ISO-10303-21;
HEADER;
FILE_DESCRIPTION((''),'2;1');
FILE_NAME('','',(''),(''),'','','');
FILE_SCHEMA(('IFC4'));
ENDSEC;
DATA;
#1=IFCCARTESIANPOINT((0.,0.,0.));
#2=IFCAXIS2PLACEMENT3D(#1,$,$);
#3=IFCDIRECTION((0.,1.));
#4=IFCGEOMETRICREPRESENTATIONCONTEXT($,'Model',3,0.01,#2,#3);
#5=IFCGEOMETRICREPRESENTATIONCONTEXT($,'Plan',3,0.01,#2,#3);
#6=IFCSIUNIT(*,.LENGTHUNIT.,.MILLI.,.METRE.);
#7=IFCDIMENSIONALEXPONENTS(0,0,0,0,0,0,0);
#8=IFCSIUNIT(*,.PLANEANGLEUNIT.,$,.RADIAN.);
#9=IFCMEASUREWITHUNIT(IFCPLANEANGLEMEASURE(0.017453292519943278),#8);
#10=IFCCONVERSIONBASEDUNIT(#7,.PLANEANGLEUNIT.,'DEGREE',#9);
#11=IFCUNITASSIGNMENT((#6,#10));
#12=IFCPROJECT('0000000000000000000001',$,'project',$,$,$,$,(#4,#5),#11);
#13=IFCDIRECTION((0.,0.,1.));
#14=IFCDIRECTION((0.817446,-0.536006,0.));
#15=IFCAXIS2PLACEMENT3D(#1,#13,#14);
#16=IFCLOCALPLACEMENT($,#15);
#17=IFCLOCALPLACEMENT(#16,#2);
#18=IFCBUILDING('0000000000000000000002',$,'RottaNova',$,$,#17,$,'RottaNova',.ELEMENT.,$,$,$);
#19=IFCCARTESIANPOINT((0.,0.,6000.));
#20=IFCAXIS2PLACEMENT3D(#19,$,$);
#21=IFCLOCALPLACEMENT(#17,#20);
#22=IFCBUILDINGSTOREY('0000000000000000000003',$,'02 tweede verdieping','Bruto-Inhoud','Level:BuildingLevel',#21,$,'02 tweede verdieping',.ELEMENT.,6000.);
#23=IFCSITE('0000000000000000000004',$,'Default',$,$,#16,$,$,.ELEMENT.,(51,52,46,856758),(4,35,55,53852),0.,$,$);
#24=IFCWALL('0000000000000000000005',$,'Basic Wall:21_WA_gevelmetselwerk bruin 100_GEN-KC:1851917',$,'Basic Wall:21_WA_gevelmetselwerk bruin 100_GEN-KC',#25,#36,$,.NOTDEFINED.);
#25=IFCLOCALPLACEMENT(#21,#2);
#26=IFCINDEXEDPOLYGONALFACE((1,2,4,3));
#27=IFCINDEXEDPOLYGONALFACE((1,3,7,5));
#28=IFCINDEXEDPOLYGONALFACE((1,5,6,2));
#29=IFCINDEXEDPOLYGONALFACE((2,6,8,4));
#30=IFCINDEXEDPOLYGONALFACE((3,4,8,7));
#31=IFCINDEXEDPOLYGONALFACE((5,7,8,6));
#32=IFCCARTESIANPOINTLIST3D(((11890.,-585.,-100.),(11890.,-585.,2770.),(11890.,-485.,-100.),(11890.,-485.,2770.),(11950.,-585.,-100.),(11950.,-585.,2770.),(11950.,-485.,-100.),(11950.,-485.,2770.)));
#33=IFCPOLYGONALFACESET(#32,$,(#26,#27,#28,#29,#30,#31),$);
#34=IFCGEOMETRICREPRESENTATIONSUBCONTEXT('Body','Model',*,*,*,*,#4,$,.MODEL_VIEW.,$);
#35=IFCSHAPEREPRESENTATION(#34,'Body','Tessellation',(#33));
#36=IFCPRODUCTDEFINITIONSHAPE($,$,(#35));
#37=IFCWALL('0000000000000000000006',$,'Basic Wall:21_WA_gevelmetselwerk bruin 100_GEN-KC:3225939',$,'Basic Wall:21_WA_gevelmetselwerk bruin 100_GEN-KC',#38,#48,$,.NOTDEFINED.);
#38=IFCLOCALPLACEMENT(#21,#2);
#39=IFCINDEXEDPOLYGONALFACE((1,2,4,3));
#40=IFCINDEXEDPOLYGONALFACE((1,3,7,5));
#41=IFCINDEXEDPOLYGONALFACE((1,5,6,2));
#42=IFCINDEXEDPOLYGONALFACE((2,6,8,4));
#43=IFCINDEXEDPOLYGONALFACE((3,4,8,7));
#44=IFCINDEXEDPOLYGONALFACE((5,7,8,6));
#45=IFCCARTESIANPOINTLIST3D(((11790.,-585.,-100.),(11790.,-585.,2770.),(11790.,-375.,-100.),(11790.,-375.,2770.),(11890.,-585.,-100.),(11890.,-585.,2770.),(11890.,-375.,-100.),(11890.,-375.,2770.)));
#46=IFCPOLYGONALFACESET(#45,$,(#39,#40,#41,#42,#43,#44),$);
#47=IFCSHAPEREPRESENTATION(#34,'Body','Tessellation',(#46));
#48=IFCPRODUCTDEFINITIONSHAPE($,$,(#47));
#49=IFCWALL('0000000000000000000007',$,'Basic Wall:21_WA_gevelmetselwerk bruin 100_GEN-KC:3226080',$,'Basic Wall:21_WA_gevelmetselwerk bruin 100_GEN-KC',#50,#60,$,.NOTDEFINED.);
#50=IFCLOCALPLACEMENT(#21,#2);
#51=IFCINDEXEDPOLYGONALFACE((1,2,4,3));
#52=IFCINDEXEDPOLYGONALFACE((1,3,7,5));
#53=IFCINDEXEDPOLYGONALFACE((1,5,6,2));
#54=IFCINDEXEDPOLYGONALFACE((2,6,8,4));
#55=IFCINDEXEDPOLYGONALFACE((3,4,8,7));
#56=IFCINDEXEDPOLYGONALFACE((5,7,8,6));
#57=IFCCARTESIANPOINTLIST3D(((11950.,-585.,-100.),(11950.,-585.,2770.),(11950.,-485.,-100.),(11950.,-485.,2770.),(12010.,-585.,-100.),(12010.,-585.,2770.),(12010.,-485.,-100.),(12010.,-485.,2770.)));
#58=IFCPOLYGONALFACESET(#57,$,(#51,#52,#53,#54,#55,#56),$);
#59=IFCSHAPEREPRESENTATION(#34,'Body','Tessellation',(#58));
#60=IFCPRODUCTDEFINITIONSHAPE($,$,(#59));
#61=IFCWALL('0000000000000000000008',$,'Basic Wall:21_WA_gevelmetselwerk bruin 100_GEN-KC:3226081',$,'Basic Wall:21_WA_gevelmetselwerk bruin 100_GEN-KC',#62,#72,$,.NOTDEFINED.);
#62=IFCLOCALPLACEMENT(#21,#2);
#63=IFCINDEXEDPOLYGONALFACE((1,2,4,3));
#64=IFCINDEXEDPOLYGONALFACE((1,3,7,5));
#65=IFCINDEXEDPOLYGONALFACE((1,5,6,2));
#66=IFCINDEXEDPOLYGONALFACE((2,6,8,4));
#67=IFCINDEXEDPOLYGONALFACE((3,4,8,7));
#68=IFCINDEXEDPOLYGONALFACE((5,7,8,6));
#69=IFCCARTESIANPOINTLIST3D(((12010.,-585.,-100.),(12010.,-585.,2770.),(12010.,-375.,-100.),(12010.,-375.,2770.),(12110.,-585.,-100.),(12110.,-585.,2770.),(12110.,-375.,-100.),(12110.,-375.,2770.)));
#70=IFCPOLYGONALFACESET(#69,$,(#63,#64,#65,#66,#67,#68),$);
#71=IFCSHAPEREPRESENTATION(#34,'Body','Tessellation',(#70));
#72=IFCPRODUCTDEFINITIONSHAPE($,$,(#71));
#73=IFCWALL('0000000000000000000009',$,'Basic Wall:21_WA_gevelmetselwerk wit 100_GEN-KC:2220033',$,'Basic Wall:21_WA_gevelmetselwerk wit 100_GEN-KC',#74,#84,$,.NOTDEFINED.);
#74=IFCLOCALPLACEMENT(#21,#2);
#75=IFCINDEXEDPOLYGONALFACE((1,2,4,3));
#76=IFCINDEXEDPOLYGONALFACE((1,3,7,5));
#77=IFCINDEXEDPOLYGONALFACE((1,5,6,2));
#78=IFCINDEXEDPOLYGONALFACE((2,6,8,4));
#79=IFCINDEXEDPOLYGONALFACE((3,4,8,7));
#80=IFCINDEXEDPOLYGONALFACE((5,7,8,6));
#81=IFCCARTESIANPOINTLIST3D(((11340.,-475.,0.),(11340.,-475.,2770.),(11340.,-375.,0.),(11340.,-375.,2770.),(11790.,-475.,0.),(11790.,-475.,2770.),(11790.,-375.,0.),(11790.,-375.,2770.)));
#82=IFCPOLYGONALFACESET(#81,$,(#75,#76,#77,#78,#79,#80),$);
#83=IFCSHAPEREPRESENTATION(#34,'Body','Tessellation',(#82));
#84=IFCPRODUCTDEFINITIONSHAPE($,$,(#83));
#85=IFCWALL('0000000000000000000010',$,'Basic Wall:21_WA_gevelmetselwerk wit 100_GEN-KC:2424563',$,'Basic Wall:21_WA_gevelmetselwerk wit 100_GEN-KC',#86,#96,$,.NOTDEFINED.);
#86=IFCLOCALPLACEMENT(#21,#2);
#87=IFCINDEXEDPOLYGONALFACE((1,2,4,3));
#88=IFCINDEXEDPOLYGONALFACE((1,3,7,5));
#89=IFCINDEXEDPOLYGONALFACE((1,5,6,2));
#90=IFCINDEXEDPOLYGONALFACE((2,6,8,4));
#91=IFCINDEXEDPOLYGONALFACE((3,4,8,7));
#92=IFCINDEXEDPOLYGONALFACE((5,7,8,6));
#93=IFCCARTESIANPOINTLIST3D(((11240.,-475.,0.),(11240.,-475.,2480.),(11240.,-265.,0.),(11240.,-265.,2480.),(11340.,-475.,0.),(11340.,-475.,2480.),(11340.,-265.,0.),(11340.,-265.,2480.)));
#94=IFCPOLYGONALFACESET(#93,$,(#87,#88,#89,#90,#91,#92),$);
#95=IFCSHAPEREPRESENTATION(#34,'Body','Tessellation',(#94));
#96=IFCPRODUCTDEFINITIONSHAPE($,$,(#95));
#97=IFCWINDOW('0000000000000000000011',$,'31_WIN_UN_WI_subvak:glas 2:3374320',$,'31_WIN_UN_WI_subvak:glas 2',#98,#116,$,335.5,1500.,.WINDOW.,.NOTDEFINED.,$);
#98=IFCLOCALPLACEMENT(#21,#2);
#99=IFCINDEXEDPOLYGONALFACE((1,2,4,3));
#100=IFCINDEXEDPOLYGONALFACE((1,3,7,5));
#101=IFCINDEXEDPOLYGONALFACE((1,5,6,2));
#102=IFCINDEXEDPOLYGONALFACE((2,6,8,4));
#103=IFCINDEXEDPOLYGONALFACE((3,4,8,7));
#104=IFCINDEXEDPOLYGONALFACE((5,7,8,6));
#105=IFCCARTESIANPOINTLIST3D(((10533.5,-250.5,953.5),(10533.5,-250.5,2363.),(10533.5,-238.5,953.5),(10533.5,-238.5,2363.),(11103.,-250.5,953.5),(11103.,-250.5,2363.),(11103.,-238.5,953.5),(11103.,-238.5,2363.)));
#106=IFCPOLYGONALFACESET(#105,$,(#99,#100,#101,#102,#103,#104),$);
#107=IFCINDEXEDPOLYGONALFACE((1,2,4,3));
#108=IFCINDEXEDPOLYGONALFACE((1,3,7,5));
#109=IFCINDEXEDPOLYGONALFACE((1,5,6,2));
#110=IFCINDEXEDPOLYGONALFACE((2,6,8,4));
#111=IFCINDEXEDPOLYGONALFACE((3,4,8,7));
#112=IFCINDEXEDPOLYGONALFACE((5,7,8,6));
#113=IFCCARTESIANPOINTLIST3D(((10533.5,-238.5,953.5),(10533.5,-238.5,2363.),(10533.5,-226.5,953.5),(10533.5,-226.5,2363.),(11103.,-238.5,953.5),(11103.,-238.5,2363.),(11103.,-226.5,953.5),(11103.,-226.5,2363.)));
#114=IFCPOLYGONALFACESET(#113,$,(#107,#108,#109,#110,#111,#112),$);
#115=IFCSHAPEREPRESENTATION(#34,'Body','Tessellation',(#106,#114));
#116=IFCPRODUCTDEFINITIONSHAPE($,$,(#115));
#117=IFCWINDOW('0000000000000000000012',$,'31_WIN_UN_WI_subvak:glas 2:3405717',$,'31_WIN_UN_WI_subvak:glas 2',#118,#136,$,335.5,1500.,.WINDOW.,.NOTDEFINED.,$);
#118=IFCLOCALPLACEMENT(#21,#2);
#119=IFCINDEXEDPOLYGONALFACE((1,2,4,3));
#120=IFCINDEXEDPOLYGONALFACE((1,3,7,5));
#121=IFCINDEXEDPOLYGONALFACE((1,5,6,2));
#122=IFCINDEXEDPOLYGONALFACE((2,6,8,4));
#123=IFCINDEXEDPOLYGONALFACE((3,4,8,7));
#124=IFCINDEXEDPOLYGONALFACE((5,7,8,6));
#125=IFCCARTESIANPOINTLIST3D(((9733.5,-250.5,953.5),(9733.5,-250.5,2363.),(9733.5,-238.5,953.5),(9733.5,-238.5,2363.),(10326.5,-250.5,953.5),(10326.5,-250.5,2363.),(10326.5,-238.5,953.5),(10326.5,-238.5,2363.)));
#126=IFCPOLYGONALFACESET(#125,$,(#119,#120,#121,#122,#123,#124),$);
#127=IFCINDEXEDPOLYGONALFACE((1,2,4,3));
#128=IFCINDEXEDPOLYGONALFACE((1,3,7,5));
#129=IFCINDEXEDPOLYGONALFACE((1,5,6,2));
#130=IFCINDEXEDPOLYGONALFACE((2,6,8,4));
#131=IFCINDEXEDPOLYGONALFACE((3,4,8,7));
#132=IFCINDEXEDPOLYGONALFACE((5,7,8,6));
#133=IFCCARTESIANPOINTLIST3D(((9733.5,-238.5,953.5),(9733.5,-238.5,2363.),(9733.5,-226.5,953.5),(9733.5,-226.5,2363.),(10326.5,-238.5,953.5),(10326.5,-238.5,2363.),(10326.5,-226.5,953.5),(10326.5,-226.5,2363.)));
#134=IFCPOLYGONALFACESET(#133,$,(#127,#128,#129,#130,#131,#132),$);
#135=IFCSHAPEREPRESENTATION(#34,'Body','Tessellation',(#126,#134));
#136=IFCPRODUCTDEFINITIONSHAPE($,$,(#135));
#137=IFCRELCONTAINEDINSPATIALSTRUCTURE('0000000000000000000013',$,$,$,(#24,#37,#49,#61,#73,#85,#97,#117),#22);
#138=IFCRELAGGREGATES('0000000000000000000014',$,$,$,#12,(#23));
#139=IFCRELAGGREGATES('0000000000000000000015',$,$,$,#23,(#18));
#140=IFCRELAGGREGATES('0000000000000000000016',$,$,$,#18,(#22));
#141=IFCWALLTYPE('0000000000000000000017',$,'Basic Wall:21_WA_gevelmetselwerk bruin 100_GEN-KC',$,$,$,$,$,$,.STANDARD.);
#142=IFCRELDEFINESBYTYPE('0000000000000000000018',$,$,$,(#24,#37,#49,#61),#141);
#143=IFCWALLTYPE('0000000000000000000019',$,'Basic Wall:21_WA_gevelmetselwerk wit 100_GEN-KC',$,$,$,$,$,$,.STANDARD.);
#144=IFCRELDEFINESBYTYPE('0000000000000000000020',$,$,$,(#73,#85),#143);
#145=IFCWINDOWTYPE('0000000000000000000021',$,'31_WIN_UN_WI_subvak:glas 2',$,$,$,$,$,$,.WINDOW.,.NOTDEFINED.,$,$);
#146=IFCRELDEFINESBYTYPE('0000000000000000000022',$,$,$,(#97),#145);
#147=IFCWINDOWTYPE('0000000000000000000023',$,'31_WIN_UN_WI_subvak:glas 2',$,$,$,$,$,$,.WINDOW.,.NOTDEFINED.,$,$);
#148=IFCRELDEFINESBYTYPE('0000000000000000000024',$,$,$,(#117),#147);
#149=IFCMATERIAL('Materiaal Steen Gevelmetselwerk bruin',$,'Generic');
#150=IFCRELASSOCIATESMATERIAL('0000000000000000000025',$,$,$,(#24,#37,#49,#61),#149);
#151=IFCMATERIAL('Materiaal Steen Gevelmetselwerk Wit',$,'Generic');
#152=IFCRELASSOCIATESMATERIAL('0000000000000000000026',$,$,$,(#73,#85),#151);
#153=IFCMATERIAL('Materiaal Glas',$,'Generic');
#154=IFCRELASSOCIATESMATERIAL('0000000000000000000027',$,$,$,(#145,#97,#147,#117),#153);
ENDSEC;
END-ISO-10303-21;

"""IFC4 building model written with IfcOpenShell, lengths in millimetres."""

from ifc_helpers import new_model, entity, si_unit, converted_unit, direction, frame, origin, place, context, subcontext, project, spatial, indexed_curve, outline, extrude, source, transform, mapped, material, type_object, type_shapes, element, save


model = new_model("IFC4")

# Units and contexts
model_context = context("Model", 3, precision=0.01, world=origin(), true_north=direction((0.0, 1.0)))
plan_context = context("Plan", 3, precision=0.01, world=origin(), true_north=direction((0.0, 1.0)))
body_context = subcontext(model_context, "Body", "Model", "MODEL_VIEW")
ifc_project = project(units=[si_unit("LENGTHUNIT", "METRE", prefix="MILLI"), converted_unit("PLANEANGLEUNIT", "DEGREE", entity("IfcPlaneAngleMeasure", 0.017453292519943278), si_unit("PLANEANGLEUNIT", "RADIAN"), dimensions=[0, 0, 0, 0, 0, 0, 0])], contexts=[model_context, plan_context])

# Site, building, storey
site_placement = place(None, frame((0.0, 0.0, 0.0), z_axis=(0.0, 0.0, 1.0), x_axis=(0.817446, -0.536006, 0.0)))
site = spatial("IfcSite", under=ifc_project, at=site_placement, Name="Default", CompositionType="ELEMENT", RefLatitude=(51, 52, 46, 856758), RefLongitude=(4, 35, 55, 53852), RefElevation=0.0)
building_placement = place(site_placement, origin())
building = spatial("IfcBuilding", under=site, at=building_placement, Name="RottaNova", LongName="RottaNova", CompositionType="ELEMENT")
storey_placement = place(building_placement, frame((0.0, 0.0, 6000.0)))
storey = spatial("IfcBuildingStorey", under=building, at=storey_placement, Name="02 tweede verdieping", Description="Bruto-Inhoud", ObjectType="Level:BuildingLevel", LongName="02 tweede verdieping", CompositionType="ELEMENT", Elevation=6000.0)

# Shared definitions
ifc_material_1 = material(Name="Materiaal Glas", Category="Generic")

# Walls
ifc_material_2 = material(Name="Materiaal Steen Gevelmetselwerk bruin", Category="Generic")
wall_type_1 = type_object("IfcWallType", Name="Basic Wall:21_WA_gevelmetselwerk bruin 100_GEN-KC", PredefinedType="STANDARD")
wall_1_placement = place(storey_placement, frame((11890.0, -535.0, -100.0)))
element("IfcWall", 1, at=wall_1_placement, inside=storey, type_object=wall_type_1, material=ifc_material_2, Name="Basic Wall:21_WA_gevelmetselwerk bruin 100_GEN-KC:1851917", ObjectType="Basic Wall:21_WA_gevelmetselwerk bruin 100_GEN-KC", PredefinedType="NOTDEFINED", context=body_context, shape_type="SweptSolid", body=[
    extrude(outline(indexed_curve([(60.0, 50.0), (0.0, 50.0), (0.0, -50.0), (60.0, -50.0), (60.0, 50.0)], self_intersect=False)), origin(), (0.0, 0.0, 1.0), 2870.0),
])
wall_2_placement = place(storey_placement, frame((11840.0, -585.0, -100.0), z_axis=(0.0, 0.0, 1.0), x_axis=(0.0, 1.0, 0.0)))
element("IfcWall", 2, at=wall_2_placement, inside=storey, type_object=wall_type_1, material=ifc_material_2, Name="Basic Wall:21_WA_gevelmetselwerk bruin 100_GEN-KC:3225939", ObjectType="Basic Wall:21_WA_gevelmetselwerk bruin 100_GEN-KC", PredefinedType="NOTDEFINED", context=body_context, shape_type="SweptSolid", body=[
    extrude(outline(indexed_curve([(210.0, 50.0), (0.0, 50.0), (0.0, -50.0), (210.0, -50.0), (210.0, 50.0)], self_intersect=False)), origin(), (0.0, 0.0, 1.0), 2870.0),
])
wall_3_placement = place(storey_placement, frame((12010.0, -535.0, -100.0), z_axis=(0.0, 0.0, 1.0), x_axis=(-1.0, 0.0, 0.0)))
element("IfcWall", 3, at=wall_3_placement, inside=storey, type_object=wall_type_1, material=ifc_material_2, Name="Basic Wall:21_WA_gevelmetselwerk bruin 100_GEN-KC:3226080", ObjectType="Basic Wall:21_WA_gevelmetselwerk bruin 100_GEN-KC", PredefinedType="NOTDEFINED", context=body_context, shape_type="SweptSolid", body=[
    extrude(outline(indexed_curve([(60.0, 50.0), (0.0, 50.0), (0.0, -50.0), (60.0, -50.0), (60.0, 50.0)], self_intersect=False)), origin(), (0.0, 0.0, 1.0), 2870.0),
])
wall_4_placement = place(storey_placement, frame((12060.0, -585.0, -100.0), z_axis=(0.0, 0.0, 1.0), x_axis=(0.0, 1.0, 0.0)))
element("IfcWall", 4, at=wall_4_placement, inside=storey, type_object=wall_type_1, material=ifc_material_2, Name="Basic Wall:21_WA_gevelmetselwerk bruin 100_GEN-KC:3226081", ObjectType="Basic Wall:21_WA_gevelmetselwerk bruin 100_GEN-KC", PredefinedType="NOTDEFINED", context=body_context, shape_type="SweptSolid", body=[
    extrude(outline(indexed_curve([(210.0, 50.0), (0.0, 50.0), (0.0, -50.0), (210.0, -50.0), (210.0, 50.0)], self_intersect=False)), origin(), (0.0, 0.0, 1.0), 2870.0),
])
ifc_material_3 = material(Name="Materiaal Steen Gevelmetselwerk Wit", Category="Generic")
wall_type_2 = type_object("IfcWallType", Name="Basic Wall:21_WA_gevelmetselwerk wit 100_GEN-KC", PredefinedType="STANDARD")
wall_5_placement = place(storey_placement, frame((11790.0, -425.0, 0.0), z_axis=(0.0, 0.0, 1.0), x_axis=(-1.0, 0.0, 0.0)))
element("IfcWall", 5, at=wall_5_placement, inside=storey, type_object=wall_type_2, material=ifc_material_3, Name="Basic Wall:21_WA_gevelmetselwerk wit 100_GEN-KC:2220033", ObjectType="Basic Wall:21_WA_gevelmetselwerk wit 100_GEN-KC", PredefinedType="NOTDEFINED", context=body_context, shape_type="SweptSolid", body=[
    extrude(outline(indexed_curve([(450.0, 50.0), (0.0, 50.0), (0.0, -50.0), (450.0, -50.0), (450.0, 50.0)], self_intersect=False)), origin(), (0.0, 0.0, 1.0), 2770.0),
])
wall_6_placement = place(storey_placement, frame((11290.0, -265.0, 0.0), z_axis=(0.0, 0.0, 1.0), x_axis=(0.0, -1.0, 0.0)))
element("IfcWall", 6, at=wall_6_placement, inside=storey, type_object=wall_type_2, material=ifc_material_3, Name="Basic Wall:21_WA_gevelmetselwerk wit 100_GEN-KC:2424563", ObjectType="Basic Wall:21_WA_gevelmetselwerk wit 100_GEN-KC", PredefinedType="NOTDEFINED", context=body_context, shape_type="SweptSolid", body=[
    extrude(outline(indexed_curve([(210.0, 50.0), (0.0, 50.0), (0.0, -50.0), (210.0, -50.0), (210.0, 50.0)], self_intersect=False)), origin(), (0.0, 0.0, 1.0), 2480.0),
])

# Windows
window_type_1 = type_object("IfcWindowType", Name="31_WIN_UN_WI_subvak:glas 2", PartitioningType="NOTDEFINED", PredefinedType="WINDOW", material=ifc_material_1)
shared_shape_1 = source(origin(), body_context, "Body", "SweptSolid", [
    extrude(outline(indexed_curve([(-284.7, -6.0), (284.7, -6.0), (284.7, 6.0), (-284.7, 6.0), (-284.7, -6.0)], self_intersect=False)), frame((0.0, -6.0, 0.0)), (0.0, 0.0, 1.0), 1409.5),
    extrude(outline(indexed_curve([(-284.8, -6.0), (284.8, -6.0), (284.8, 6.0), (-284.8, 6.0), (-284.8, -6.0)], self_intersect=False)), frame((0.0, 6.0, 0.0)), (0.0, 0.0, 1.0), 1409.5),
])
type_shapes(window_type_1, [shared_shape_1])
window_1_placement = place(storey_placement, frame((10818.2, -238.5, 953.5)))
element("IfcWindow", 7, at=window_1_placement, inside=storey, type_object=window_type_1, material=ifc_material_1, Name="31_WIN_UN_WI_subvak:glas 2:3374320", ObjectType="31_WIN_UN_WI_subvak:glas 2", OverallHeight=335.5, OverallWidth=1500.0, PartitioningType="NOTDEFINED", PredefinedType="WINDOW", context=body_context, shape_type="MappedRepresentation", body=[
    mapped(shared_shape_1, transform((0.0, 0.0, 0.0), scale=1.0)),
])
window_type_2 = type_object("IfcWindowType", Name="31_WIN_UN_WI_subvak:glas 2", PartitioningType="NOTDEFINED", PredefinedType="WINDOW", material=ifc_material_1)
shared_shape_2 = source(origin(), body_context, "Body", "SweptSolid", [
    extrude(outline(indexed_curve([(-296.5, -6.0), (296.5, -6.0), (296.5, 6.0), (-296.5, 6.0), (-296.5, -6.0)], self_intersect=False)), frame((0.0, -6.0, 0.0)), (0.0, 0.0, 1.0), 1409.5),
    extrude(outline(indexed_curve([(-296.5, -6.0), (296.5, -6.0), (296.5, 6.0), (-296.5, 6.0), (-296.5, -6.0)], self_intersect=False)), frame((0.0, 6.0, 0.0)), (0.0, 0.0, 1.0), 1409.5),
])
type_shapes(window_type_2, [shared_shape_2])
window_2_placement = place(storey_placement, frame((10030.0, -238.5, 953.5)))
element("IfcWindow", 8, at=window_2_placement, inside=storey, type_object=window_type_2, material=ifc_material_1, Name="31_WIN_UN_WI_subvak:glas 2:3405717", ObjectType="31_WIN_UN_WI_subvak:glas 2", OverallHeight=335.5, OverallWidth=1500.0, PartitioningType="NOTDEFINED", PredefinedType="WINDOW", context=body_context, shape_type="MappedRepresentation", body=[
    mapped(shared_shape_2, transform((0.0, 0.0, 0.0), scale=1.0)),
])

save(model, "model.ifc")
